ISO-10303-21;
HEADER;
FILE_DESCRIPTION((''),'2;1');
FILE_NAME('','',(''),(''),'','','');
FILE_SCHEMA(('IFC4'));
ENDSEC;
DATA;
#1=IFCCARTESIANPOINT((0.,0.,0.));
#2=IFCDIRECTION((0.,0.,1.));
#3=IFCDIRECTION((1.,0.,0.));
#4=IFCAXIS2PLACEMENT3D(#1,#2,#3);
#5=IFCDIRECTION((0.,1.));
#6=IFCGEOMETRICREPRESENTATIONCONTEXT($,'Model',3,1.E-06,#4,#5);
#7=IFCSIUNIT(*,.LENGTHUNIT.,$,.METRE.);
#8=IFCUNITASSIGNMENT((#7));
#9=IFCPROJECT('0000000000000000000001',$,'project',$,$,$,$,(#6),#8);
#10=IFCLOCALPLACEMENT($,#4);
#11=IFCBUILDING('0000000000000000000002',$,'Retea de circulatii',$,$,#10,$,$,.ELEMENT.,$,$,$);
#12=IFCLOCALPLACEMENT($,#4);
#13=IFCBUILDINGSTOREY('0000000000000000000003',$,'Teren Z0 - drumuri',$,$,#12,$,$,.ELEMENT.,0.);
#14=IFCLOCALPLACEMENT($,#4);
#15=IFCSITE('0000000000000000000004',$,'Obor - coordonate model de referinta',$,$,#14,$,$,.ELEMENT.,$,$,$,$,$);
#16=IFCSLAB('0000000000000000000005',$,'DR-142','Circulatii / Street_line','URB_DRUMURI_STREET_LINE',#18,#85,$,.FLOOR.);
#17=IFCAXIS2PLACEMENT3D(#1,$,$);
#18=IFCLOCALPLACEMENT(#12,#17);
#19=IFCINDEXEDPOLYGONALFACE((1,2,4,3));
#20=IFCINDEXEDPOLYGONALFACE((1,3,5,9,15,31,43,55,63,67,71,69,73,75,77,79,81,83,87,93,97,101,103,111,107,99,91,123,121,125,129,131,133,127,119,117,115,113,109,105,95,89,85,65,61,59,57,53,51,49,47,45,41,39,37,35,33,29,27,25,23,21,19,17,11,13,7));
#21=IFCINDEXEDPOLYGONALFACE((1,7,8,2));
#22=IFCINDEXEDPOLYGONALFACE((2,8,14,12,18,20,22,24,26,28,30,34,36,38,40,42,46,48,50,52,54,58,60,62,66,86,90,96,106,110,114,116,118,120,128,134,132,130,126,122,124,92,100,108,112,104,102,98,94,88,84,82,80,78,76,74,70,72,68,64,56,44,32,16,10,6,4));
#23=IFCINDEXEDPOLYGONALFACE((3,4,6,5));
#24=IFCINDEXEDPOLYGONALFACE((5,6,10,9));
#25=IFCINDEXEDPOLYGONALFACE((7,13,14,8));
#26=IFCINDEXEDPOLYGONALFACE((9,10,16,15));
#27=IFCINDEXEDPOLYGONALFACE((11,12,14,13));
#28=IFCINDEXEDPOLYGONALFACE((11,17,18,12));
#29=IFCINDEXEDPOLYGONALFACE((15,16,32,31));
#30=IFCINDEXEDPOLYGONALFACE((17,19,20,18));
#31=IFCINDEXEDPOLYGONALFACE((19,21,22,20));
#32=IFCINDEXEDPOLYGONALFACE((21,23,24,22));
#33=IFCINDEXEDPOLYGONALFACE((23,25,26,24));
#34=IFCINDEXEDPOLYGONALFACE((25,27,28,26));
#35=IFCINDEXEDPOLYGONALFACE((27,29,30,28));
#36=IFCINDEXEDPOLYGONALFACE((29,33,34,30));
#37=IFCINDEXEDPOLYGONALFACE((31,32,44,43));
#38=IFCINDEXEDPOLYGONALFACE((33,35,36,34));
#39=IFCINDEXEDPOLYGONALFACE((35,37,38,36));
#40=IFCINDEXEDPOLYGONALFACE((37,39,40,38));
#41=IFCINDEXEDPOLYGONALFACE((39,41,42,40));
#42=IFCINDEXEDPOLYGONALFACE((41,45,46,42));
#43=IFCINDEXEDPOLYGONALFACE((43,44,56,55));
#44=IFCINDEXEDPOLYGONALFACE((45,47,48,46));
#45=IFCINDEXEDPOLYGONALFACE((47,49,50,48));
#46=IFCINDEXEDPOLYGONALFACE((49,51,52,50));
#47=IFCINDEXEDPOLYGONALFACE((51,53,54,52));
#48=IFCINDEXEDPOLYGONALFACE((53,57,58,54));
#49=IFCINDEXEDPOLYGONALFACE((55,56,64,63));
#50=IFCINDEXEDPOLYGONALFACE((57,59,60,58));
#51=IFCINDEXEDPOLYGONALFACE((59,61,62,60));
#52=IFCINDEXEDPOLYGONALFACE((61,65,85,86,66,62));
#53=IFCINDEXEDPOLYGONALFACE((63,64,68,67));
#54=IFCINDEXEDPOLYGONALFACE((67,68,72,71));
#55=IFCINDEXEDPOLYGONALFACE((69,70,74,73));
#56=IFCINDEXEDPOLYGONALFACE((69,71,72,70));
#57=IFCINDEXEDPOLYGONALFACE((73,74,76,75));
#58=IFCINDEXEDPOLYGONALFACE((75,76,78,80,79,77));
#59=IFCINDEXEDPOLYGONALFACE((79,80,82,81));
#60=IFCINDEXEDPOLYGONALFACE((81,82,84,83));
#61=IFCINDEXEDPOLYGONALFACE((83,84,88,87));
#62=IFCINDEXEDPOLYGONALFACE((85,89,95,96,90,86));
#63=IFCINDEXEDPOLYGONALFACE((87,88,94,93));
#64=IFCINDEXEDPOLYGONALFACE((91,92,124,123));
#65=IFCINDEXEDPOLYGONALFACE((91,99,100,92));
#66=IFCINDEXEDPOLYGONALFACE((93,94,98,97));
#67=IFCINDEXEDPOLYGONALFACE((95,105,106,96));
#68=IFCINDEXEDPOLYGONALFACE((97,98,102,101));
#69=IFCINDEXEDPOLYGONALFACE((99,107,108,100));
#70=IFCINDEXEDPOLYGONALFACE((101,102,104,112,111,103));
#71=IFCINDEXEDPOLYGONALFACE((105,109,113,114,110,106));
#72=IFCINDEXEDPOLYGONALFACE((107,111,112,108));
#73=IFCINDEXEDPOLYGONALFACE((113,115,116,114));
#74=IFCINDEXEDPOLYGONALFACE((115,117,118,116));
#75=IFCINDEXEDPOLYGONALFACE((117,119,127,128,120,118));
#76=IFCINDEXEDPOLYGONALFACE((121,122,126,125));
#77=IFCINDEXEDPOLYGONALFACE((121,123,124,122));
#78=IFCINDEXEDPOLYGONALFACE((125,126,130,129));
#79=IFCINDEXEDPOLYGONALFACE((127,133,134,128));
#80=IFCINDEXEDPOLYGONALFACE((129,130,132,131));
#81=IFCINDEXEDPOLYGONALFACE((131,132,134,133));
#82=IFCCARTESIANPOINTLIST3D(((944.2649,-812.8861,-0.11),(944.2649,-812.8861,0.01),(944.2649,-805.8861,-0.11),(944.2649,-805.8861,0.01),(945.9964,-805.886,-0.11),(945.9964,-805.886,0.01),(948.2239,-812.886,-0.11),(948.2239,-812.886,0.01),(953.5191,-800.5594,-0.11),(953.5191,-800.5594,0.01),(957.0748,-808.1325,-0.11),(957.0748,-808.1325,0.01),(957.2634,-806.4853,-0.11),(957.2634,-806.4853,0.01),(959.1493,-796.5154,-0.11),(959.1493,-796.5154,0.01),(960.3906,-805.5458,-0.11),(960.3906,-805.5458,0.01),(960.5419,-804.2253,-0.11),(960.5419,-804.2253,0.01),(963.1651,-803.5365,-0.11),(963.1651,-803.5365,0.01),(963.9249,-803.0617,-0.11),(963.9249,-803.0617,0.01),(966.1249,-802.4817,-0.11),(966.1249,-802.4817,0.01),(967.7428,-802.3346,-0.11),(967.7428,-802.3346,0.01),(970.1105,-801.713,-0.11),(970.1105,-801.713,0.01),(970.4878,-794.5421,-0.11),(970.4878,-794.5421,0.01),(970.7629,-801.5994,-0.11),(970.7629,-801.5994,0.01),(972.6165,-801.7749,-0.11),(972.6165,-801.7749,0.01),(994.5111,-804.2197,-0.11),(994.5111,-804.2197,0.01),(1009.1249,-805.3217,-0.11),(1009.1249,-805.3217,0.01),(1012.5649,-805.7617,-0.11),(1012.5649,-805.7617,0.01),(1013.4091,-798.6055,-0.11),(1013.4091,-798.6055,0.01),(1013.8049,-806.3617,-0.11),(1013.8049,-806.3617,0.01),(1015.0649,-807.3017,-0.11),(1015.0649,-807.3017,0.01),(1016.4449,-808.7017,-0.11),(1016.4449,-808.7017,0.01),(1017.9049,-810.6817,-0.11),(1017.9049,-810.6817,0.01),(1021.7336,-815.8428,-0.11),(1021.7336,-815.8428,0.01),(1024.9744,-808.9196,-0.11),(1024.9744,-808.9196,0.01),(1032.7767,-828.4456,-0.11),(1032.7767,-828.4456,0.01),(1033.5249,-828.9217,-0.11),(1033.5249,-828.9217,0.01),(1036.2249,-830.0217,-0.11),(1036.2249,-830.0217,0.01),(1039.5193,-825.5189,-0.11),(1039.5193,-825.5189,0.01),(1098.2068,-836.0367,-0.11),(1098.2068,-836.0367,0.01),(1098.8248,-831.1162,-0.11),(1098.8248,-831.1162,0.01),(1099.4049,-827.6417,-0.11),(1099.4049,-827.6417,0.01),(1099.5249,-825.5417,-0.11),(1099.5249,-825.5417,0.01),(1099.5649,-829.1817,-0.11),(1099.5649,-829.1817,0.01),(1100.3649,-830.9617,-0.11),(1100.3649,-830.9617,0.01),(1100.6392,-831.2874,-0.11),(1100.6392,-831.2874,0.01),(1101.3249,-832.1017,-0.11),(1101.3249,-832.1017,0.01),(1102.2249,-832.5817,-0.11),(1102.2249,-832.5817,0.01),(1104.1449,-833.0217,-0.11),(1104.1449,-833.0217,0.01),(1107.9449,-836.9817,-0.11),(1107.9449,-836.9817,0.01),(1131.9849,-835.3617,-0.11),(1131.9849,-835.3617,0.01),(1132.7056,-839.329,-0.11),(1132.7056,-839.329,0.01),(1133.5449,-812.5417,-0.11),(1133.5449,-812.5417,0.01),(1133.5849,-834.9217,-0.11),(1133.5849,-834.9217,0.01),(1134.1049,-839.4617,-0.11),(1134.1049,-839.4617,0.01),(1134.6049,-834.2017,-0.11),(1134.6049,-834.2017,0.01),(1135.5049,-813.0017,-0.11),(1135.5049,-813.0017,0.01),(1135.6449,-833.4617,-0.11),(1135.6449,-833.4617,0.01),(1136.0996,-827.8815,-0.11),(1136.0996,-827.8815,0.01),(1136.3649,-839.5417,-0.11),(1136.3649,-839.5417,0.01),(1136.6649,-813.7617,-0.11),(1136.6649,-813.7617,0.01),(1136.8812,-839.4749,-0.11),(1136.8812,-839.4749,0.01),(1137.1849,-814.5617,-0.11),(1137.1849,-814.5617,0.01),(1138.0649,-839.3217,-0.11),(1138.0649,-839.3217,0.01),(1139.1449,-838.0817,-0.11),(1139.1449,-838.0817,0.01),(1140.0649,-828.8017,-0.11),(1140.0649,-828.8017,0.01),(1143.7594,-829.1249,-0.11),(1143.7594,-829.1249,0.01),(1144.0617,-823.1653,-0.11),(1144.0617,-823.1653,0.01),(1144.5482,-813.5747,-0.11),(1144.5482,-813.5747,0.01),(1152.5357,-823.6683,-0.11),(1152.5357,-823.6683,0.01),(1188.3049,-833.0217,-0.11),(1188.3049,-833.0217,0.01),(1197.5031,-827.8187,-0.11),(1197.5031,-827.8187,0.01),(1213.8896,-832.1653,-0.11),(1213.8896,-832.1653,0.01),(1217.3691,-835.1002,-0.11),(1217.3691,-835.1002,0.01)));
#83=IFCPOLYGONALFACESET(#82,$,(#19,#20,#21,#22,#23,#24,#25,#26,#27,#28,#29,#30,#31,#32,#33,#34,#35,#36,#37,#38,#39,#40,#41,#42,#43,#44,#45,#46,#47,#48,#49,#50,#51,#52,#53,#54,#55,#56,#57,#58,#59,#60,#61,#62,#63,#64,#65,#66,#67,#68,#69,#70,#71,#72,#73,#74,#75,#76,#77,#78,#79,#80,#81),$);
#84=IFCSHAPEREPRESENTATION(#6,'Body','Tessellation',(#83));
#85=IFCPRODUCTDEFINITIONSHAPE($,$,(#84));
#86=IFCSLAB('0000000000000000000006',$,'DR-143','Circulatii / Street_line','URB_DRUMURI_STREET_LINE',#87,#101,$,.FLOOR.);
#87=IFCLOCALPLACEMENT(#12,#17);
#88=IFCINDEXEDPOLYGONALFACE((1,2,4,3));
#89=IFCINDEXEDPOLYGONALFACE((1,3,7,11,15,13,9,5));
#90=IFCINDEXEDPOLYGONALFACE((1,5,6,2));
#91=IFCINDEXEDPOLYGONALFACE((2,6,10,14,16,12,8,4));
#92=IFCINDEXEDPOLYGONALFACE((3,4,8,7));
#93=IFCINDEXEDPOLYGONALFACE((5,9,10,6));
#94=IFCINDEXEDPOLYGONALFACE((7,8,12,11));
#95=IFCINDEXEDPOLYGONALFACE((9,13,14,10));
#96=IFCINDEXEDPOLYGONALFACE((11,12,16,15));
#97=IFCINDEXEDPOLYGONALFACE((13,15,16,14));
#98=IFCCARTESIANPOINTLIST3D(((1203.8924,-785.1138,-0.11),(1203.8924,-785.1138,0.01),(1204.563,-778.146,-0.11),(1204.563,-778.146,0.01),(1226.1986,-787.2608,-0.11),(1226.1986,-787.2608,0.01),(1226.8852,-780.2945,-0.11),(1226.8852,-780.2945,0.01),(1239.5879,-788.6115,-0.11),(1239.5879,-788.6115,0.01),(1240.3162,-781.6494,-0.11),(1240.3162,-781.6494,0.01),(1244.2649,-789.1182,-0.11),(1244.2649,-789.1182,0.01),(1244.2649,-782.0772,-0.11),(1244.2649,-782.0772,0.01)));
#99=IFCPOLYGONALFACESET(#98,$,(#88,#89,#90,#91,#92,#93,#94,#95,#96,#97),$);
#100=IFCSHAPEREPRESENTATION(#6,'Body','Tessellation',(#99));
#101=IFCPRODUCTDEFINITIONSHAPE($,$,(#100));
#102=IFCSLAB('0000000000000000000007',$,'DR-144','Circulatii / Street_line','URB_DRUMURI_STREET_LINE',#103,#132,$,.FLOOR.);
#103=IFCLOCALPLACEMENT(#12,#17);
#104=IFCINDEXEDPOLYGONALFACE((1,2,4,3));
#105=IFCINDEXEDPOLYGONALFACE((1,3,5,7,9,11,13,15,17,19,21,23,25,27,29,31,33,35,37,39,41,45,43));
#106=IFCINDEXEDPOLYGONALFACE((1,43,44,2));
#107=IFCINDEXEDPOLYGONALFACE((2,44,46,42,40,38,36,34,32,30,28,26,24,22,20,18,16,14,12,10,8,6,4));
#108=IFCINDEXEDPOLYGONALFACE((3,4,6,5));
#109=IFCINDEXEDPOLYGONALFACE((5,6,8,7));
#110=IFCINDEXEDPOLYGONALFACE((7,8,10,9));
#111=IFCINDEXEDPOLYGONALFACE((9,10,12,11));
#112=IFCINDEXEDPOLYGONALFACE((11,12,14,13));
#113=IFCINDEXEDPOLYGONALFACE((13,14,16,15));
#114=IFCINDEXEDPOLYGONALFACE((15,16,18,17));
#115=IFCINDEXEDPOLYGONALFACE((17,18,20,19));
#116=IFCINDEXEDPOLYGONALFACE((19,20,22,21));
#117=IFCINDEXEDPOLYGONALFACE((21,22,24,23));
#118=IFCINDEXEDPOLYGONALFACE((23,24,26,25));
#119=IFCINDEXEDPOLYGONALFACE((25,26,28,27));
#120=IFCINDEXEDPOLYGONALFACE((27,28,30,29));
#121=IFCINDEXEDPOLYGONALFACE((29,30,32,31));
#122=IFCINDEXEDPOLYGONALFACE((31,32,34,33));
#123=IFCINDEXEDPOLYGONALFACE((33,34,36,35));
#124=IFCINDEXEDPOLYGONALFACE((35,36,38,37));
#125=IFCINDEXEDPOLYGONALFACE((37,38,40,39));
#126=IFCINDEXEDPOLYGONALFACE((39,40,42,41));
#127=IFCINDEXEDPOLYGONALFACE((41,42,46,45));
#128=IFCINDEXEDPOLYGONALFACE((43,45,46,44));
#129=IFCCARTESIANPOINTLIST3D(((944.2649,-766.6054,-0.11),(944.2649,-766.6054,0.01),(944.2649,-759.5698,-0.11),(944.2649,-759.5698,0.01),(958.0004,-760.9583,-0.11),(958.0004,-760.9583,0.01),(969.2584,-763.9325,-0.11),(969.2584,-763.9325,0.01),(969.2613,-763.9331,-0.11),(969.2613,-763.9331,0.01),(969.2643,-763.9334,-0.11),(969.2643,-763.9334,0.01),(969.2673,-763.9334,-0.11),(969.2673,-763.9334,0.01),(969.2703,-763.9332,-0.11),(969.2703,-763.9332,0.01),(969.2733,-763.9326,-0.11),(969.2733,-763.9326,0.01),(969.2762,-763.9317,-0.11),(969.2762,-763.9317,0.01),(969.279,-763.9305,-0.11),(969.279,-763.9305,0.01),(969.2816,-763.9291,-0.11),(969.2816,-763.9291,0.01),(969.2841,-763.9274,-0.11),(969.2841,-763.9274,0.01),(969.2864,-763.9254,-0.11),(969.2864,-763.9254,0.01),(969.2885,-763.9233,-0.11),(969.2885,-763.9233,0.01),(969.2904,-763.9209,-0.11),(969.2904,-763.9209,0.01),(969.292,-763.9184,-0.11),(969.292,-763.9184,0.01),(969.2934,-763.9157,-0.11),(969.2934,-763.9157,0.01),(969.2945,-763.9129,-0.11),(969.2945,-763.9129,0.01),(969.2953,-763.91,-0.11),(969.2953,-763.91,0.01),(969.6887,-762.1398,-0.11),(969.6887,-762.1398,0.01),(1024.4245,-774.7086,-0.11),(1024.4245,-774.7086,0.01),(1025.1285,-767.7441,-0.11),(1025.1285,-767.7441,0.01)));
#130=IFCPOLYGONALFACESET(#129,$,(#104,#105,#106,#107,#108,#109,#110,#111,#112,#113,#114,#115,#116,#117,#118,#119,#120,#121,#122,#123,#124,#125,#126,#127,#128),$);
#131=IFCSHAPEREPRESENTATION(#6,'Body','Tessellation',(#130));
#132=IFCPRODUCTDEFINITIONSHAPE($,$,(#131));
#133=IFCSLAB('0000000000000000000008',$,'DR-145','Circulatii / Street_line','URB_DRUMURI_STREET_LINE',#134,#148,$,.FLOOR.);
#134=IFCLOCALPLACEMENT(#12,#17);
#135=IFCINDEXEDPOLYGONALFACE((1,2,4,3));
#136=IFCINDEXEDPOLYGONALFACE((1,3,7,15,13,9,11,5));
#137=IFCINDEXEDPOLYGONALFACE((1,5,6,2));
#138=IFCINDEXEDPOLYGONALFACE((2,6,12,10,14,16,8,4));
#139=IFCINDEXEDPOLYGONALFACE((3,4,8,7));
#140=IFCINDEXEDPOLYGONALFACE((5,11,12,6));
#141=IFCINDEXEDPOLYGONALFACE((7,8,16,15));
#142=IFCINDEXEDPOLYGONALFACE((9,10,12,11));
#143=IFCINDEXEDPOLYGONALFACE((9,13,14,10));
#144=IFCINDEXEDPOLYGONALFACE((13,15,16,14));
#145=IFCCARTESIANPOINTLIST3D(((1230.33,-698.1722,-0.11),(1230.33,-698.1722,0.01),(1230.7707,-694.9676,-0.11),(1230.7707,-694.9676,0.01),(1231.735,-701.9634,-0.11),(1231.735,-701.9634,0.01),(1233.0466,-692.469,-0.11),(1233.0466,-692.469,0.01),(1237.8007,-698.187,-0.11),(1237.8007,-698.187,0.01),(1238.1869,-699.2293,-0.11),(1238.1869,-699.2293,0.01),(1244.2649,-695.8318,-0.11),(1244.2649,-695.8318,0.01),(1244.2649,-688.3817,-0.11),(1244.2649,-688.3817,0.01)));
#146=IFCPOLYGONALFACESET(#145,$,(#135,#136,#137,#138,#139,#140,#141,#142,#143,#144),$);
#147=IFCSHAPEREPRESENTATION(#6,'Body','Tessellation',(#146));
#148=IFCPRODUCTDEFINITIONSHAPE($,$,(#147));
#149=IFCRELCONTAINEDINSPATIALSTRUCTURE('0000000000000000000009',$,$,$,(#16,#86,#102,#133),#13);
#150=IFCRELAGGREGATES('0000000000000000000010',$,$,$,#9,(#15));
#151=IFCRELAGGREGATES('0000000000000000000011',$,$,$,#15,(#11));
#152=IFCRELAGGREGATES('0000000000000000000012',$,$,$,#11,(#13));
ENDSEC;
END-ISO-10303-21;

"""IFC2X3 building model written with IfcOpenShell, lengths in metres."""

from ifc_helpers import new_model, si_unit, direction, frame, origin_with_axes, place, context, project, spatial, polyline, outline, extrude, element, save


model = new_model("IFC2X3")

# Units and contexts
model_context = context("Model", 3, precision=1e-06, world=origin_with_axes(), true_north=direction((0.0, 1.0)))
ifc_project = project(units=[si_unit("LENGTHUNIT", "METRE")], contexts=[model_context])

# Site, building, storey
site_placement = place(None, origin_with_axes())
site = spatial("IfcSite", under=ifc_project, at=site_placement, Name="Obor - coordonate model de referinta", CompositionType="ELEMENT")
building_placement = place(None, origin_with_axes())
building = spatial("IfcBuilding", under=site, at=building_placement, Name="Retea de circulatii", CompositionType="ELEMENT")
storey_placement = place(None, origin_with_axes())
storey = spatial("IfcBuildingStorey", under=building, at=storey_placement, Name="Teren Z0 - drumuri", CompositionType="ELEMENT", Elevation=0.0)

# Slabs
slab_1_placement = place(None, origin_with_axes())
element("IfcSlab", 1, at=slab_1_placement, inside=storey, Name="DR-142", Description="Circulatii / Street_line", ObjectType="URB_DRUMURI_STREET_LINE", PredefinedType="FLOOR", context=model_context, shape_type="SweptSolid", body=[
    extrude(outline(polyline([(970.4878, -794.5421), (959.1493, -796.5154), (953.5191, -800.5594), (945.9964, -805.886), (944.2649, -805.8861), (944.2649, -812.8861), (948.2239, -812.886), (957.2634, -806.4853), (957.0748, -808.1325), (960.3906, -805.5458), (960.5419, -804.2253), (963.1651, -803.5365), (963.9249, -803.0617), (966.1249, -802.4817), (967.7428, -802.3346), (970.1105, -801.713), (970.7629, -801.5994), (972.6165, -801.7749), (994.5111, -804.2197), (1009.1249, -805.3217), (1012.5649, -805.7617), (1013.8049, -806.3617), (1015.0649, -807.3017), (1016.4449, -808.7017), (1017.9049, -810.6817), (1021.7336, -815.8428), (1032.7767, -828.4456), (1033.5249, -828.9217), (1036.2249, -830.0217), (1098.2068, -836.0367), (1107.9449, -836.9817), (1132.7056, -839.329), (1134.1049, -839.4617), (1136.3649, -839.5417), (1136.8812, -839.4749), (1138.0649, -839.3217), (1139.1449, -838.0817), (1140.0649, -828.8017), (1143.7594, -829.1249), (1188.3049, -833.0217), (1217.3691, -835.1002), (1213.8896, -832.1653), (1197.5031, -827.8187), (1152.5357, -823.6683), (1144.0617, -823.1653), (1144.5482, -813.5747), (1133.5449, -812.5417), (1135.5049, -813.0017), (1136.6649, -813.7617), (1137.1849, -814.5617), (1136.0996, -827.8815), (1135.6449, -833.4617), (1134.6049, -834.2017), (1133.5849, -834.9217), (1131.9849, -835.3617), (1104.1449, -833.0217), (1102.2249, -832.5817), (1101.3249, -832.1017), (1100.6392, -831.2874), (1100.3649, -830.9617), (1099.5649, -829.1817), (1099.4049, -827.6417), (1099.5249, -825.5417), (1098.8248, -831.1162), (1039.5193, -825.5189), (1024.9744, -808.9196), (1013.4091, -798.6055), (970.4878, -794.5421)])), frame((0.0, 0.0, -0.11), z_axis=(0.0, 0.0, 1.0), x_axis=(1.0, 0.0, 0.0)), (0.0, 0.0, 1.0), 0.12),
])
slab_2_placement = place(None, origin_with_axes())
element("IfcSlab", 2, at=slab_2_placement, inside=storey, Name="DR-143", Description="Circulatii / Street_line", ObjectType="URB_DRUMURI_STREET_LINE", PredefinedType="FLOOR", context=model_context, shape_type="SweptSolid", body=[
    extrude(outline(polyline([(1226.8852, -780.2945), (1204.563, -778.146), (1203.8924, -785.1138), (1226.1986, -787.2608), (1239.5879, -788.6115), (1244.2649, -789.1182), (1244.2649, -782.0772), (1240.3162, -781.6494), (1226.8852, -780.2945)])), frame((0.0, 0.0, -0.11), z_axis=(0.0, 0.0, 1.0), x_axis=(1.0, 0.0, 0.0)), (0.0, 0.0, 1.0), 0.12),
])
slab_3_placement = place(None, origin_with_axes())
element("IfcSlab", 3, at=slab_3_placement, inside=storey, Name="DR-144", Description="Circulatii / Street_line", ObjectType="URB_DRUMURI_STREET_LINE", PredefinedType="FLOOR", context=model_context, shape_type="SweptSolid", body=[
    extrude(outline(polyline([(969.2673, -763.9334), (969.2643, -763.9334), (969.2613, -763.9331), (969.2584, -763.9325), (958.0004, -760.9583), (944.2649, -759.5698), (944.2649, -766.6054), (1024.4245, -774.7086), (1025.1285, -767.7441), (969.6887, -762.1398), (969.2953, -763.91), (969.2945, -763.9129), (969.2934, -763.9157), (969.292, -763.9184), (969.2904, -763.9209), (969.2885, -763.9233), (969.2864, -763.9254), (969.2841, -763.9274), (969.2816, -763.9291), (969.279, -763.9305), (969.2762, -763.9317), (969.2733, -763.9326), (969.2703, -763.9332), (969.2673, -763.9334)])), frame((0.0, 0.0, -0.11), z_axis=(0.0, 0.0, 1.0), x_axis=(1.0, 0.0, 0.0)), (0.0, 0.0, 1.0), 0.12),
])
slab_4_placement = place(None, origin_with_axes())
element("IfcSlab", 4, at=slab_4_placement, inside=storey, Name="DR-145", Description="Circulatii / Street_line", ObjectType="URB_DRUMURI_STREET_LINE", PredefinedType="FLOOR", context=model_context, shape_type="SweptSolid", body=[
    extrude(outline(polyline([(1230.33, -698.1722), (1231.735, -701.9634), (1238.1869, -699.2293), (1237.8007, -698.187), (1244.2649, -695.8318), (1244.2649, -688.3817), (1233.0466, -692.469), (1230.7707, -694.9676), (1230.33, -698.1722)])), frame((0.0, 0.0, -0.11), z_axis=(0.0, 0.0, 1.0), x_axis=(1.0, 0.0, 0.0)), (0.0, 0.0, 1.0), 0.12),
])

save(model, "model.ifc")
